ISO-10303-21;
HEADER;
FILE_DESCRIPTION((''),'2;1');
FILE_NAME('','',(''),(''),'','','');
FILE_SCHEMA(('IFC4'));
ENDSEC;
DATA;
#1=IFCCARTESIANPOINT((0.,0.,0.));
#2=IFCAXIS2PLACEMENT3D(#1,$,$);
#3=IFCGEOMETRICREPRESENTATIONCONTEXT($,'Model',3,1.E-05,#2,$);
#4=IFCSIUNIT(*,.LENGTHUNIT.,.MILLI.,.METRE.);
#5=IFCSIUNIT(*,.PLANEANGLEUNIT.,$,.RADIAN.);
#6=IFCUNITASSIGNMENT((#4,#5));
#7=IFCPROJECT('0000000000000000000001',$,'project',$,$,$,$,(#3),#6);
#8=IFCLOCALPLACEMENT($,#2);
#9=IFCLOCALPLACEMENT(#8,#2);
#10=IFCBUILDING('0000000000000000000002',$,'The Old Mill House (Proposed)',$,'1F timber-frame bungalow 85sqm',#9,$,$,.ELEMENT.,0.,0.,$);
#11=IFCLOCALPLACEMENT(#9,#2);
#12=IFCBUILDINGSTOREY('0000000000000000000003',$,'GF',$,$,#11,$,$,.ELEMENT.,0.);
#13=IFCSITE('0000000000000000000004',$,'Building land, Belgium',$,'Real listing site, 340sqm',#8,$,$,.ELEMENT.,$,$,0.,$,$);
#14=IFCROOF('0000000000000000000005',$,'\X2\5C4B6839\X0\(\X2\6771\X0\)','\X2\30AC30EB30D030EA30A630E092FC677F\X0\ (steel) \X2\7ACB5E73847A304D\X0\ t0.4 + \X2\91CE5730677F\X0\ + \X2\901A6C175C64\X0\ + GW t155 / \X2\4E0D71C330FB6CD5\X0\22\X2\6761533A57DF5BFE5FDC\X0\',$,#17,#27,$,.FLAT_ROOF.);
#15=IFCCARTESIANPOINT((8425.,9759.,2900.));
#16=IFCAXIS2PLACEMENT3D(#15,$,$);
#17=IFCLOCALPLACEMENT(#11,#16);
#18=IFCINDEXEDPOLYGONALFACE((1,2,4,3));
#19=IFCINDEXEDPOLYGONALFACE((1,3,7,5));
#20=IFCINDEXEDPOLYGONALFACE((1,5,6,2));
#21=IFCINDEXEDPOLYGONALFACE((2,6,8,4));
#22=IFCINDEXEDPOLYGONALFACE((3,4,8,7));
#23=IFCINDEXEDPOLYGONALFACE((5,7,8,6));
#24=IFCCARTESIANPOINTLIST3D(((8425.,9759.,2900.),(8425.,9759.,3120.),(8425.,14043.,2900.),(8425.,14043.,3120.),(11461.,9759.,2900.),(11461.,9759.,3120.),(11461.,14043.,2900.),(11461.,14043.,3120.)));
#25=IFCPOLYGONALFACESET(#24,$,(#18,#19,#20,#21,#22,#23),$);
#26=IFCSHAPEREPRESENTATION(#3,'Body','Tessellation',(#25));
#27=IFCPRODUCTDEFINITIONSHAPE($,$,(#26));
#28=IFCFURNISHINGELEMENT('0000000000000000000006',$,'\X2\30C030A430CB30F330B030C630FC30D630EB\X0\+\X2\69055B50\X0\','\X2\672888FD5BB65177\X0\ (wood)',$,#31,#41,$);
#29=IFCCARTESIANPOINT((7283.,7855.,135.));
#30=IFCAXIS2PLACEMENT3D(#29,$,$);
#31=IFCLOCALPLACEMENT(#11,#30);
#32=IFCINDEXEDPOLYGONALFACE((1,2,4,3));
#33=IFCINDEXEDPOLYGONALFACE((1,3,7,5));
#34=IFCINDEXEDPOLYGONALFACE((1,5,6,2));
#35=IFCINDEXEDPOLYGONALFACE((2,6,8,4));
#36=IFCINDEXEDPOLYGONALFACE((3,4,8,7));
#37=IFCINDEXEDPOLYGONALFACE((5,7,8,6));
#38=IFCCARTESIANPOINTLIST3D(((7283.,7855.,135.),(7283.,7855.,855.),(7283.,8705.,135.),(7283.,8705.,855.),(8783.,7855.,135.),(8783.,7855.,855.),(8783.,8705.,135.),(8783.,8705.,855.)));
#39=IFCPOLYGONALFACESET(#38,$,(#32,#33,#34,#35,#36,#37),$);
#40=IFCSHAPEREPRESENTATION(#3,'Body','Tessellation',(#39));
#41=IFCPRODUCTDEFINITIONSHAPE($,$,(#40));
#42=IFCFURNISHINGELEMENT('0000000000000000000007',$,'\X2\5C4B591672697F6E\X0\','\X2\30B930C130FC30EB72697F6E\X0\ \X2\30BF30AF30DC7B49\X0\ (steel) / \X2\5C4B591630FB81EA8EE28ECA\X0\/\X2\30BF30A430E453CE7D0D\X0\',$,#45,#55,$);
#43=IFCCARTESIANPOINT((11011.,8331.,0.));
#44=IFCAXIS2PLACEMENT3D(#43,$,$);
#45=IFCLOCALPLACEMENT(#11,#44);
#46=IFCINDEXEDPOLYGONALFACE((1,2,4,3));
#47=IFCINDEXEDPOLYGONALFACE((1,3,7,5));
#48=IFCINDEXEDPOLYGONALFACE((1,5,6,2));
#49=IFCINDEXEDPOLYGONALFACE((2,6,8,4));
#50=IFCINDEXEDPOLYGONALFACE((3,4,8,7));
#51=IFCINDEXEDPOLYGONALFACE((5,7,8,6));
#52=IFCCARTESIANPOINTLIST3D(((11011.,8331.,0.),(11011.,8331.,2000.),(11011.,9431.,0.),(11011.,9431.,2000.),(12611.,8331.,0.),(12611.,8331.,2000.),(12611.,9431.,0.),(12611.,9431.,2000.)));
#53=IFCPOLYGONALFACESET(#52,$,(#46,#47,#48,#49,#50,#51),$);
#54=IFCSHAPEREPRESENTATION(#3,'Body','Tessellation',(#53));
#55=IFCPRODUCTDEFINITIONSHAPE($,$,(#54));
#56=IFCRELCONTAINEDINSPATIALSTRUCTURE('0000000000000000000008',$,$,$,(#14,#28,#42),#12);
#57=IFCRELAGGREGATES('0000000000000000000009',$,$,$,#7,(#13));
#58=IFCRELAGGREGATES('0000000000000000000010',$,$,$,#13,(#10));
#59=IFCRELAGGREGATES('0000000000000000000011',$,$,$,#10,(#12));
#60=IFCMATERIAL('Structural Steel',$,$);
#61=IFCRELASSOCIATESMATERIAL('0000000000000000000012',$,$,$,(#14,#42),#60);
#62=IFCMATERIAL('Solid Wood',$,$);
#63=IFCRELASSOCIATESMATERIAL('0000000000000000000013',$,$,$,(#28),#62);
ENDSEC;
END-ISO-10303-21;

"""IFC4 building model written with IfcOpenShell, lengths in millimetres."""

from ifc_helpers import new_model, si_unit, frame, frame_2d, origin, place, context, project, spatial, rectangle, extrude, material, element, save


model = new_model("IFC4")

# Units and contexts
model_context = context("Model", 3, precision=1e-05, world=origin())
ifc_project = project(units=[si_unit("LENGTHUNIT", "METRE", prefix="MILLI"), si_unit("PLANEANGLEUNIT", "RADIAN")], contexts=[model_context])

# Site, building, storey
site_placement = place(None, origin())
site = spatial("IfcSite", under=ifc_project, at=site_placement, Name="Building land, Belgium", ObjectType="Real listing site, 340sqm", CompositionType="ELEMENT", RefElevation=0.0)
building_placement = place(site_placement, origin())
building = spatial("IfcBuilding", under=site, at=building_placement, Name="The Old Mill House (Proposed)", ObjectType="1F timber-frame bungalow 85sqm", CompositionType="ELEMENT", ElevationOfRefHeight=0.0, ElevationOfTerrain=0.0)
storey_placement = place(building_placement, origin())
storey = spatial("IfcBuildingStorey", under=building, at=storey_placement, Name="GF", CompositionType="ELEMENT", Elevation=0.0)

# Shared definitions
ifc_material_1 = material(Name="Solid Wood")

# Roof
ifc_material_2 = material(Name="Structural Steel")
roof_1_placement = place(storey_placement, frame((8425.0, 9759.0, 2900.0)))
element("IfcRoof", 1, at=roof_1_placement, inside=storey, material=ifc_material_2, Name="屋根(東)", Description="ガルバリウム鋼板 (steel) 立平葺き t0.4 + 野地板 + 通気層 + GW t155 / 不燃・法22条区域対応", PredefinedType="FLAT_ROOF", context=model_context, shape_type="SweptSolid", body=[
    extrude(rectangle(XDim=3036.0, YDim=4284.0, at=frame_2d((1518.0, 2142.0))), frame((8425.0, 9759.0, 2900.0)), (0.0, 0.0, 1.0), 220.0),
])

# Furnishing elements
furnishing_1_placement = place(storey_placement, frame((7283.0, 7855.0, 135.0)))
element("IfcFurnishingElement", 2, at=furnishing_1_placement, inside=storey, material=ifc_material_1, Name="ダイニングテーブル+椅子", Description="木製家具 (wood)", context=model_context, shape_type="SweptSolid", body=[
    extrude(rectangle(XDim=1500.0, YDim=850.0, at=frame_2d((750.0, 425.0))), frame((7283.0, 7855.0, 135.0)), (0.0, 0.0, 1.0), 720.0),
])
furnishing_2_placement = place(storey_placement, frame((11011.0, 8331.0, 0.0)))
element("IfcFurnishingElement", 3, at=furnishing_2_placement, inside=storey, material=ifc_material_2, Name="屋外物置", Description="スチール物置 タクボ等 (steel) / 屋外・自転車/タイヤ収納", context=model_context, shape_type="SweptSolid", body=[
    extrude(rectangle(XDim=1600.0, YDim=1100.0, at=frame_2d((800.0, 550.0))), frame((11011.0, 8331.0, 0.0)), (0.0, 0.0, 1.0), 2000.0),
])

save(model, "model.ifc")
